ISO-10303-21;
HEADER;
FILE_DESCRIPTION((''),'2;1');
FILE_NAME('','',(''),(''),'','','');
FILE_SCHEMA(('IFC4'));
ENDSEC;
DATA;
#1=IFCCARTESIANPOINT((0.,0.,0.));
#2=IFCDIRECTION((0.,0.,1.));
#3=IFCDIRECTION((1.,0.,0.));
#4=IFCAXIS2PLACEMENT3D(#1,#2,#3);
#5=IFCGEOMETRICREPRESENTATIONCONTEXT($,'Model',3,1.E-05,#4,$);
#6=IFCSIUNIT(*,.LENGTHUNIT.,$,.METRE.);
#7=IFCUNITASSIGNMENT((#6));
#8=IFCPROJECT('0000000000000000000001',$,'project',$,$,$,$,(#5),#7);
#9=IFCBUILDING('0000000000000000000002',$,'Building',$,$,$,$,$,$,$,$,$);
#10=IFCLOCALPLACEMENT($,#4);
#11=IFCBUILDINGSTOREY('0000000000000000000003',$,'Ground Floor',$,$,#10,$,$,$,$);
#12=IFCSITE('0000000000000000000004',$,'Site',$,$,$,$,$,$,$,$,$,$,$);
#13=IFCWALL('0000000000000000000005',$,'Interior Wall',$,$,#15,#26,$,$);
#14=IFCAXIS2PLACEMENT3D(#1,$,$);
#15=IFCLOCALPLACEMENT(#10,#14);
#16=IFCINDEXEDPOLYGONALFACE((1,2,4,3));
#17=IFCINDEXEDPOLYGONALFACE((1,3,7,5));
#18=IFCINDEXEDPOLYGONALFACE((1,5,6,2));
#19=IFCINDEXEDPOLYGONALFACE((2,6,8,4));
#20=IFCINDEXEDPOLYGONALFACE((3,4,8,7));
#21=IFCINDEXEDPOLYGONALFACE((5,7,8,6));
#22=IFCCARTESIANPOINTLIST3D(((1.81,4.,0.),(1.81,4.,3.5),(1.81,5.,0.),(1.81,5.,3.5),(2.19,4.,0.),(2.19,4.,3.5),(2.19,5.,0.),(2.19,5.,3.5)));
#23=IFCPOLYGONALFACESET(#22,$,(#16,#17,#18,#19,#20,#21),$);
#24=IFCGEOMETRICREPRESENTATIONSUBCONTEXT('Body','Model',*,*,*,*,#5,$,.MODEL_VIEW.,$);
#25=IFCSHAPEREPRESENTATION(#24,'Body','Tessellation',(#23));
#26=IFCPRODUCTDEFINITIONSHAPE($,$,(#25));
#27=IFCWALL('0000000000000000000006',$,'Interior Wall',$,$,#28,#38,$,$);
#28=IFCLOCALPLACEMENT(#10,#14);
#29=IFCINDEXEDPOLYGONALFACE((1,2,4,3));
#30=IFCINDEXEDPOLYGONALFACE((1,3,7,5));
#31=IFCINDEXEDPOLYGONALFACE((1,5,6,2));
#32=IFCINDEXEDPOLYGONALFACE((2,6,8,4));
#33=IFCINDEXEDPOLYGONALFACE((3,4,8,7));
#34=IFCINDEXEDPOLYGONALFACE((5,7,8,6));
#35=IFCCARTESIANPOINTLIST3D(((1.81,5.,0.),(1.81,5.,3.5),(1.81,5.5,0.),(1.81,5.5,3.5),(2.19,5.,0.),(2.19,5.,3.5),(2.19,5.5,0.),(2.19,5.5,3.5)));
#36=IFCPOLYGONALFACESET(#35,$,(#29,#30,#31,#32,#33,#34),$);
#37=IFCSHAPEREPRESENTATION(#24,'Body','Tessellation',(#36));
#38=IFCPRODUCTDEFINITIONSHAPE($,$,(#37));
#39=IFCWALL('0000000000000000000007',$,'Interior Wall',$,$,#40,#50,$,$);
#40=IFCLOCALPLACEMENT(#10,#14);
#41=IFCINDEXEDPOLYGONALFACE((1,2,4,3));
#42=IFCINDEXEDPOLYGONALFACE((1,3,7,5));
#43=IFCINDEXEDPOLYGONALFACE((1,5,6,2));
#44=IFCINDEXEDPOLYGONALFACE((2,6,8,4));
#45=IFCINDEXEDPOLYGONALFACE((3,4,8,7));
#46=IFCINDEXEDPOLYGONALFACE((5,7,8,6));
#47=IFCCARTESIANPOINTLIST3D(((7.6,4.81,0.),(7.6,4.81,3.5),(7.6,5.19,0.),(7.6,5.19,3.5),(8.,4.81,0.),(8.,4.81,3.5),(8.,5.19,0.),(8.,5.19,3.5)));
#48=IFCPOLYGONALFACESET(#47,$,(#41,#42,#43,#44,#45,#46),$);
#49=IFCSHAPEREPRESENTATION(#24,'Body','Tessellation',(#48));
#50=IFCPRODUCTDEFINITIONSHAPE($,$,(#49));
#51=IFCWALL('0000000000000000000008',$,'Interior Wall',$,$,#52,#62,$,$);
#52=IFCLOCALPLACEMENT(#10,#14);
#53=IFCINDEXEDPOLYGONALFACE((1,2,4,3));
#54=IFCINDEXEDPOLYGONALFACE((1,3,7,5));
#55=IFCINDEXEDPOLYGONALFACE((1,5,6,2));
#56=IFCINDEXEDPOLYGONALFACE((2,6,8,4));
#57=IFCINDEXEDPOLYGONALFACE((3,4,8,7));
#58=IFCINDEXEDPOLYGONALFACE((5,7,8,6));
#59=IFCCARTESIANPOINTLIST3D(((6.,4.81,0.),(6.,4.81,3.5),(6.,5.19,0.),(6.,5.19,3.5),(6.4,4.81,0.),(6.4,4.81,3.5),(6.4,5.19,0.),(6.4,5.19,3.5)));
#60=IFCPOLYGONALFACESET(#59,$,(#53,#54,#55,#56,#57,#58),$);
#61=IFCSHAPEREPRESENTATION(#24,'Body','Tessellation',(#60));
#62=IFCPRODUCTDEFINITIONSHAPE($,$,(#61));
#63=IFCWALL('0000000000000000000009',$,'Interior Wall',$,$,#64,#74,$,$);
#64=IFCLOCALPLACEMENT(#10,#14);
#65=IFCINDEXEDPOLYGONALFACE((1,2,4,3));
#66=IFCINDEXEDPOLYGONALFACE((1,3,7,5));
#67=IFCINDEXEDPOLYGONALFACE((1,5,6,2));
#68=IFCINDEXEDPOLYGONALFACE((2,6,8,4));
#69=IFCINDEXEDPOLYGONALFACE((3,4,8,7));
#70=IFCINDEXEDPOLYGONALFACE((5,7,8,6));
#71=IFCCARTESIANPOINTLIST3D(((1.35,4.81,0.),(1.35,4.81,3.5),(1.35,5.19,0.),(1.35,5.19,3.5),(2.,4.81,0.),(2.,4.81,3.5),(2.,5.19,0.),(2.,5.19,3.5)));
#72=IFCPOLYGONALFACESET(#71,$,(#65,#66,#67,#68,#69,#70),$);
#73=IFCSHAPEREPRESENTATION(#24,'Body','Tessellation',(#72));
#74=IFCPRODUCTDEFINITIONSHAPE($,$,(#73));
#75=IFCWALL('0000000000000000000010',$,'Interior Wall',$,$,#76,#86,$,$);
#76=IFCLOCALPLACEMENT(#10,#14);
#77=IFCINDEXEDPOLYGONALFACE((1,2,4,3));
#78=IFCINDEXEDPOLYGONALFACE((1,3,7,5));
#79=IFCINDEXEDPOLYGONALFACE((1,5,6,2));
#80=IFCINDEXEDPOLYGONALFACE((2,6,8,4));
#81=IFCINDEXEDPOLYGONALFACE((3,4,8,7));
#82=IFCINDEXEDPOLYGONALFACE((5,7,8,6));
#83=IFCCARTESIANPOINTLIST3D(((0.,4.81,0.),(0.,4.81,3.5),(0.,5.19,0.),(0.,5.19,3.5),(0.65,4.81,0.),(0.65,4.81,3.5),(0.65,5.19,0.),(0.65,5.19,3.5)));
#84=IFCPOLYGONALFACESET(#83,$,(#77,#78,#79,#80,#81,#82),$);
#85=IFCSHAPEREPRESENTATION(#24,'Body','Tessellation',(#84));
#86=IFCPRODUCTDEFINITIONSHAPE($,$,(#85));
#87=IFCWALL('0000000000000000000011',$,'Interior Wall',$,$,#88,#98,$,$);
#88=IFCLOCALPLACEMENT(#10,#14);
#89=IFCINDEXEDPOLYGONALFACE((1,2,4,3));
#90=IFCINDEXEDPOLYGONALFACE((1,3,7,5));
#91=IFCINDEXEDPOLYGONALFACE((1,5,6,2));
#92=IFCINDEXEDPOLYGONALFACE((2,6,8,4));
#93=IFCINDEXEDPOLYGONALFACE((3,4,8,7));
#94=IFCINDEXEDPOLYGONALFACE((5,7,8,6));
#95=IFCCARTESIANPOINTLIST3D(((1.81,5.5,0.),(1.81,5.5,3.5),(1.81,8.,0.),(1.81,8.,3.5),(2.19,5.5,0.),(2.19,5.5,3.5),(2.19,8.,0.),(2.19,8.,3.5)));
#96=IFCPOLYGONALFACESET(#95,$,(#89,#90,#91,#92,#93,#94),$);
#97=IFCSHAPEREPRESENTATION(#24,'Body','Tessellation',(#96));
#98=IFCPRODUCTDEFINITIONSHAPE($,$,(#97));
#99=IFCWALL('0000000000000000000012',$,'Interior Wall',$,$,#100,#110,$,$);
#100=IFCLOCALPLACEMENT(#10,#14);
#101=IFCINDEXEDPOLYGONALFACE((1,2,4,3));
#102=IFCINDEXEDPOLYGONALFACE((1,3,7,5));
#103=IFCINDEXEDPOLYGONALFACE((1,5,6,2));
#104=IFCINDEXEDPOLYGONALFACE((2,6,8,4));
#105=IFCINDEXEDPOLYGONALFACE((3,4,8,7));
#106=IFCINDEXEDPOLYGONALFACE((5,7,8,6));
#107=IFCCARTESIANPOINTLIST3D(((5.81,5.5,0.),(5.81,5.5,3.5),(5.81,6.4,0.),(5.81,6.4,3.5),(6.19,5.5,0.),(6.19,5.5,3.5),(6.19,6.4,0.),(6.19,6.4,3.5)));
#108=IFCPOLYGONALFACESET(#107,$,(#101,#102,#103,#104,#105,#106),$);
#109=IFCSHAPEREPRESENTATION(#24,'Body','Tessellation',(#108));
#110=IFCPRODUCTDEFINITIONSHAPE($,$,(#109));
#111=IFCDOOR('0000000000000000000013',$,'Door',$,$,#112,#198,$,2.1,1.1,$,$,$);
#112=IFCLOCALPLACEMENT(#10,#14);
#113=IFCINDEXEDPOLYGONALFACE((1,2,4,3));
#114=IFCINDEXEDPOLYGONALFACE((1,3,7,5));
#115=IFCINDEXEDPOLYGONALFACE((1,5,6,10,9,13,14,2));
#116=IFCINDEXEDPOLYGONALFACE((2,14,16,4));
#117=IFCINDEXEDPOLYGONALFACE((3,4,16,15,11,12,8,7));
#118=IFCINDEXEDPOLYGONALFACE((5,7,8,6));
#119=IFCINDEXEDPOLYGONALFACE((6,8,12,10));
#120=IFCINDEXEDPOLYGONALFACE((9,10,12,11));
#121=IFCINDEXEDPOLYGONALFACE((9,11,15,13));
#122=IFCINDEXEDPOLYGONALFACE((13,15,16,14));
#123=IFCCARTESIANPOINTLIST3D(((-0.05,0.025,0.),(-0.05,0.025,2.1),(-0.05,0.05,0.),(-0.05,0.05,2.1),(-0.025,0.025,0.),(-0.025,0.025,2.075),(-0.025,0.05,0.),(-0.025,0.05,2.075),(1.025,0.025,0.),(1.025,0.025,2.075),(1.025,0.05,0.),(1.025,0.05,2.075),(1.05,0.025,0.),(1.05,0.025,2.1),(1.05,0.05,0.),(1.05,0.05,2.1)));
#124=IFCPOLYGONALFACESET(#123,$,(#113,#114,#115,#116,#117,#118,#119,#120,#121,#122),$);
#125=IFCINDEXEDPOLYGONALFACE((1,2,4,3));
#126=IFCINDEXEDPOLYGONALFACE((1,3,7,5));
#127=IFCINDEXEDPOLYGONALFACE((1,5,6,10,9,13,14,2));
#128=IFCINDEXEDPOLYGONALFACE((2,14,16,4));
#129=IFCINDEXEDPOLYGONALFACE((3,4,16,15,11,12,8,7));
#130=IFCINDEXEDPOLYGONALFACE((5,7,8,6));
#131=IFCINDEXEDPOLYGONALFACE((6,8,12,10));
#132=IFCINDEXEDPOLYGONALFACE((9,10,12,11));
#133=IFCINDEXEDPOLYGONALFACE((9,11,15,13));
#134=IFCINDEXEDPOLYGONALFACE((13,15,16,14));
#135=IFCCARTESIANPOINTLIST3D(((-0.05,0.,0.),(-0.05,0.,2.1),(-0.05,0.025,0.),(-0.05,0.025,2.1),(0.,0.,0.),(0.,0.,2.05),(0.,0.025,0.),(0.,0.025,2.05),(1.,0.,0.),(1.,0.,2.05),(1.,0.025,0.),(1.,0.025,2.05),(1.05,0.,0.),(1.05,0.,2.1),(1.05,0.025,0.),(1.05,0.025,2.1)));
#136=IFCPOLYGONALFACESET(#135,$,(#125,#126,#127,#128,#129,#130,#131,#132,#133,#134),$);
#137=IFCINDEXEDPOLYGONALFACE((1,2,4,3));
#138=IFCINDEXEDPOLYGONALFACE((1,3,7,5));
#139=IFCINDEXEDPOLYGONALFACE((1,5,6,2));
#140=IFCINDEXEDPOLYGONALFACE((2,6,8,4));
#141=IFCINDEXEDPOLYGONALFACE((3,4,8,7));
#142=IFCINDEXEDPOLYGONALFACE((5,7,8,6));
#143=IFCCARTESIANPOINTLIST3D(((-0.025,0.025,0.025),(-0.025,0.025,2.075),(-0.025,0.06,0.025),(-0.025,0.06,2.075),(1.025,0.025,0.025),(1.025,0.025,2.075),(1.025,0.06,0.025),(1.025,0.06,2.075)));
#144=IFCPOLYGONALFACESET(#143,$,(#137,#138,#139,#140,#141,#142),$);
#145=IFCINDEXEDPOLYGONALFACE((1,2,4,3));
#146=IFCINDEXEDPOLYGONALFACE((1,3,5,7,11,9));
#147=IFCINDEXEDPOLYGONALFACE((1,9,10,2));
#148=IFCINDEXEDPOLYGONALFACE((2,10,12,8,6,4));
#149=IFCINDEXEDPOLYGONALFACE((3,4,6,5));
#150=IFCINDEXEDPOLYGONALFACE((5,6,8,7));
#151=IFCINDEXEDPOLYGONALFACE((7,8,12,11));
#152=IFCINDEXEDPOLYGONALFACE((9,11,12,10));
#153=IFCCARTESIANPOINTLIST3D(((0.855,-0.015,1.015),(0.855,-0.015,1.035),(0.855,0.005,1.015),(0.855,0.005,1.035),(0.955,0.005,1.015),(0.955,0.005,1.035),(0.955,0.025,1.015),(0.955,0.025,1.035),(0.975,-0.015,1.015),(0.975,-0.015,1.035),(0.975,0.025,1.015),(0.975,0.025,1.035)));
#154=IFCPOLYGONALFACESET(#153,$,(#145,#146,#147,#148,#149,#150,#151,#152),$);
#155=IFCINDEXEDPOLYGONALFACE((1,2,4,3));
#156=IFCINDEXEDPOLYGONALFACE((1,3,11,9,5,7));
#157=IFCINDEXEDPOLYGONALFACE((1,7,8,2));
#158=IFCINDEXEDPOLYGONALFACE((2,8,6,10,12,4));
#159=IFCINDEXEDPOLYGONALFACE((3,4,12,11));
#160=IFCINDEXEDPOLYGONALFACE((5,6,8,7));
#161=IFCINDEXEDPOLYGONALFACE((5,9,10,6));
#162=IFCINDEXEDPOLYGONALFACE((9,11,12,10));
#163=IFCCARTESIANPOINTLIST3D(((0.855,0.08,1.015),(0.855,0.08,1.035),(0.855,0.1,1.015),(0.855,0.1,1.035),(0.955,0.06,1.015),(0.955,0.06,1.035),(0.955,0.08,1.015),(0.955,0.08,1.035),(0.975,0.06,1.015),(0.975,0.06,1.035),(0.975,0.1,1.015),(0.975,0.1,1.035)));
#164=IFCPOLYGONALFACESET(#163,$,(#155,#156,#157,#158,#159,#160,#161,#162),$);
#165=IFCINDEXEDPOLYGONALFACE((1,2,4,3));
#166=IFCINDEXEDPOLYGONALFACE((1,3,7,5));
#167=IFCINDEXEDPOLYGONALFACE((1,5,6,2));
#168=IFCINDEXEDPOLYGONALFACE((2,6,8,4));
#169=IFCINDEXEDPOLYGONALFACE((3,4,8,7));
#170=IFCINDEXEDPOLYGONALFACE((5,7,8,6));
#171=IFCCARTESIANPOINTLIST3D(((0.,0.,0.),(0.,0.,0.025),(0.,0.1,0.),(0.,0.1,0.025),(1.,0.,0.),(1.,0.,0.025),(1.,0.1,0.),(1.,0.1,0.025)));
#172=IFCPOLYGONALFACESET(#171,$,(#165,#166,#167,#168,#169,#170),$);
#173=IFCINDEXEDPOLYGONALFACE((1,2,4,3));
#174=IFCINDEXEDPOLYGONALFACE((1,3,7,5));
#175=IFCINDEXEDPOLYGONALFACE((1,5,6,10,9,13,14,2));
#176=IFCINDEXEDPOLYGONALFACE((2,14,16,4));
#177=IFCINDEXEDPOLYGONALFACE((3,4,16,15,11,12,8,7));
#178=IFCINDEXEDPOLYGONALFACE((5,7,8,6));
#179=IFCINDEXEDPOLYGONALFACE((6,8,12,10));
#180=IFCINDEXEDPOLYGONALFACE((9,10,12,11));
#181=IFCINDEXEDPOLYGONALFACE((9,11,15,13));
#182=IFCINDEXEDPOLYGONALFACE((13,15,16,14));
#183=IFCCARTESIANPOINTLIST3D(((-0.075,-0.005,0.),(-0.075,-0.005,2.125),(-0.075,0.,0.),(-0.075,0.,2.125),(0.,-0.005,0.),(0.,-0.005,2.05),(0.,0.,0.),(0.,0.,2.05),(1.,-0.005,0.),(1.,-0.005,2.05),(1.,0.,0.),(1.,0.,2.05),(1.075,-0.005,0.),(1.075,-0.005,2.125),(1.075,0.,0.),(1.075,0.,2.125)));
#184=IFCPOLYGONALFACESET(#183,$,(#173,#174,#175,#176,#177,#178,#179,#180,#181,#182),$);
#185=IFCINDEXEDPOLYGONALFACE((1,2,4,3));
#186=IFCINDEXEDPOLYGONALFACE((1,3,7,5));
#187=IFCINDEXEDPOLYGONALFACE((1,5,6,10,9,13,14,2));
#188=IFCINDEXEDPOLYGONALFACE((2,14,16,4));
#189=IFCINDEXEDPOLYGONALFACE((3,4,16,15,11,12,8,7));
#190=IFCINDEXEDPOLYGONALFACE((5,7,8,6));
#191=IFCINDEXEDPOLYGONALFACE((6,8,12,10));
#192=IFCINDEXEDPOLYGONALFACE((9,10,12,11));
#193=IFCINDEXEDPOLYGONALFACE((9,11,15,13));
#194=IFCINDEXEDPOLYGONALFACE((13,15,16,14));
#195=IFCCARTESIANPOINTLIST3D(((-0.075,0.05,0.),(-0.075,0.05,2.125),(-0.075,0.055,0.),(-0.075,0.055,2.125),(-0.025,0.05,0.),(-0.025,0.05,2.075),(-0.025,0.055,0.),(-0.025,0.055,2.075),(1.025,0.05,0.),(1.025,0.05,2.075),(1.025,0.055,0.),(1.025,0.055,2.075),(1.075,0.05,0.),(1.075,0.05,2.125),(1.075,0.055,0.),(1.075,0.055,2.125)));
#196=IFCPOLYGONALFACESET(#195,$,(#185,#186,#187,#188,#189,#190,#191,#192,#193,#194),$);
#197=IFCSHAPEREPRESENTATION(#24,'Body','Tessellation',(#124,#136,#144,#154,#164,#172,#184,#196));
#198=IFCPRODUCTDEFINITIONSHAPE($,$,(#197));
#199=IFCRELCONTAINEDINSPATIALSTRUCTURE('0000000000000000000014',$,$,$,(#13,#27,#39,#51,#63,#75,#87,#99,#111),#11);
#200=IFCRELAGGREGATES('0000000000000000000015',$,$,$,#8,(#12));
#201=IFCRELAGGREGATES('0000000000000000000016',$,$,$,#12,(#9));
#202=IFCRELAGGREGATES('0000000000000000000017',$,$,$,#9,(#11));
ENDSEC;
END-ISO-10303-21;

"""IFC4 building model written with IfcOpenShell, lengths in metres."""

from ifc_helpers import new_model, si_unit, frame, origin_with_axes, place, context, subcontext, project, spatial, line, indexed_curve, outline, extrude, element, save


model = new_model("IFC4")

# Units and contexts
model_context = context("Model", 3, precision=1e-05, world=origin_with_axes())
body_context = subcontext(model_context, "Body", "Model", "MODEL_VIEW")
ifc_project = project(units=[si_unit("LENGTHUNIT", "METRE")], contexts=[model_context])

# Site, building, storey
site = spatial("IfcSite", under=ifc_project, Name="Site")
building = spatial("IfcBuilding", under=site, Name="Building")
storey_placement = place(None, origin_with_axes())
storey = spatial("IfcBuildingStorey", under=building, at=storey_placement, Name="Ground Floor")

# Walls
wall_1_placement = place(storey_placement, frame((2.0, 5.0, 0.0), z_axis=(0.0, 0.0, 1.0), x_axis=(0.0, -1.0, 0.0)))
element("IfcWall", 1, at=wall_1_placement, inside=storey, Name="Interior Wall", context=body_context, shape_type="SweptSolid", body=[
    extrude(outline(indexed_curve([(0.0, 0.0), (0.0, 0.38), (1.0, 0.38), (1.0, 0.0), (0.0, 0.0)], self_intersect=False)), frame((0.0, -0.19, 0.0), z_axis=(0.0, 0.0, 1.0), x_axis=(1.0, 0.0, 0.0)), (0.0, 0.0, 1.0), 3.5),
])
wall_2_placement = place(storey_placement, frame((2.0, 5.5, 0.0), z_axis=(0.0, 0.0, 1.0), x_axis=(0.0, -1.0, 0.0)))
element("IfcWall", 2, at=wall_2_placement, inside=storey, Name="Interior Wall", context=body_context, shape_type="SweptSolid", body=[
    extrude(outline(indexed_curve([(0.0, 0.0), (0.0, 0.38), (0.5, 0.38), (0.5, 0.0), (0.0, 0.0)], self_intersect=False)), frame((0.0, -0.19, 0.0), z_axis=(0.0, 0.0, 1.0), x_axis=(1.0, 0.0, 0.0)), (0.0, 0.0, 1.0), 3.5),
])
for number, where, z_axis, x_axis, name in (
    (3, (8.0, 5.0, 0.0), (0.0, 0.0, 1.0), (-1.0, 0.0, 0.0), "Interior Wall"),
    (4, (6.4, 5.0, 0.0), (0.0, 0.0, 1.0), (-1.0, 0.0, 0.0), "Interior Wall"),
):
    element("IfcWall", number, at=place(storey_placement, frame(where, z_axis=z_axis, x_axis=x_axis)), inside=storey, Name=name, context=body_context, shape_type="SweptSolid", body=[
        extrude(outline(indexed_curve([(0.0, 0.0), (0.0, 0.38), (0.4, 0.38), (0.4, 0.0), (0.0, 0.0)], self_intersect=False)), frame((0.0, -0.19, 0.0), z_axis=(0.0, 0.0, 1.0), x_axis=(1.0, 0.0, 0.0)), (0.0, 0.0, 1.0), 3.5),
    ])
for number, where, z_axis, x_axis, name in (
    (5, (2.0, 5.0, 0.0), (0.0, 0.0, 1.0), (-1.0, 0.0, 0.0), "Interior Wall"),
    (6, (0.65, 5.0, 0.0), (0.0, 0.0, 1.0), (-1.0, 0.0, 0.0), "Interior Wall"),
):
    element("IfcWall", number, at=place(storey_placement, frame(where, z_axis=z_axis, x_axis=x_axis)), inside=storey, Name=name, context=body_context, shape_type="SweptSolid", body=[
        extrude(outline(indexed_curve([(0.0, 0.0), (0.0, 0.38), (0.65, 0.38), (0.65, 0.0), (0.0, 0.0)], self_intersect=False)), frame((0.0, -0.19, 0.0), z_axis=(0.0, 0.0, 1.0), x_axis=(1.0, 0.0, 0.0)), (0.0, 0.0, 1.0), 3.5),
    ])
wall_3_placement = place(storey_placement, frame((2.0, 5.5, 0.0), z_axis=(0.0, 0.0, 1.0), x_axis=(0.0, 1.0, 0.0)))
element("IfcWall", 7, at=wall_3_placement, inside=storey, Name="Interior Wall", context=body_context, shape_type="SweptSolid", body=[
    extrude(outline(indexed_curve([(0.0, 0.0), (0.0, 0.38), (2.5, 0.38), (2.5, 0.0), (0.0, 0.0)], self_intersect=False)), frame((0.0, -0.19, 0.0), z_axis=(0.0, 0.0, 1.0), x_axis=(1.0, 0.0, 0.0)), (0.0, 0.0, 1.0), 3.5),
])
wall_4_placement = place(storey_placement, frame((6.0, 5.5, 0.0), z_axis=(0.0, 0.0, 1.0), x_axis=(0.0, 1.0, 0.0)))
element("IfcWall", 8, at=wall_4_placement, inside=storey, Name="Interior Wall", context=body_context, shape_type="SweptSolid", body=[
    extrude(outline(indexed_curve([(0.0, 0.0), (0.0, 0.38), (0.9, 0.38), (0.9, 0.0), (0.0, 0.0)], self_intersect=False)), frame((0.0, -0.19, 0.0), z_axis=(0.0, 0.0, 1.0), x_axis=(1.0, 0.0, 0.0)), (0.0, 0.0, 1.0), 3.5),
])

# Door
door_1_placement = place(storey_placement, frame((-0.05, 0.0, 0.0), z_axis=(0.0, 0.0, 1.0), x_axis=(1.0, 0.0, 0.0)))
element("IfcDoor", 9, at=door_1_placement, inside=storey, Name="Door", OverallHeight=2.1, OverallWidth=1.1, context=body_context, shape_type="SweptSolid", body=[
    extrude(outline(indexed_curve([(0.0, 0.0), (0.0, 2.1), (1.1, 2.1), (1.1, 0.0), (1.075, 0.0), (1.075, 2.075), (0.025, 2.075), (0.025, 0.0)], segments=[line(1, 2, 3, 4, 5, 6, 7, 8, 1)])), frame((0.0, 0.025, 0.0), z_axis=(0.0, -1.0, 0.0), x_axis=(1.0, 0.0, 0.0)), (0.0, 0.0, -1.0), 0.025),
    extrude(outline(indexed_curve([(0.0, 0.0), (0.0, 2.1), (1.1, 2.1), (1.1, 0.0), (1.05, 0.0), (1.05, 2.05), (0.05, 2.05), (0.05, 0.0)], segments=[line(1, 2, 3, 4, 5, 6, 7, 8, 1)])), frame((0.0, 0.0, 0.0), z_axis=(0.0, -1.0, 0.0), x_axis=(1.0, 0.0, 0.0)), (0.0, 0.0, -1.0), 0.025),
    extrude(outline(indexed_curve([(0.0, 0.0), (1.05, 0.0), (1.05, 0.035), (0.0, 0.035)], segments=[line(1, 2, 3, 4, 1)])), frame((0.025, 0.025, 0.025), z_axis=(0.0, 0.0, 1.0), x_axis=(1.0, 0.0, 0.0)), (0.0, 0.0, 1.0), 2.05),
    extrude(outline(indexed_curve([(0.0, 0.0), (0.0, -0.04), (-0.12, -0.04), (-0.12, -0.02), (-0.02, -0.02), (-0.02, 0.0)], segments=[line(1, 2, 3, 4, 5, 6, 1)])), frame((1.025, 0.025, 1.015), z_axis=(0.0, 0.0, 1.0), x_axis=(1.0, 0.0, 0.0)), (0.0, 0.0, 1.0), 0.02),
    extrude(outline(indexed_curve([(0.0, 0.0), (0.0, 0.04), (-0.12, 0.04), (-0.12, 0.02), (-0.02, 0.02), (-0.02, 0.0)], segments=[line(1, 2, 3, 4, 5, 6, 1)])), frame((1.025, 0.06, 1.015), z_axis=(0.0, 0.0, 1.0), x_axis=(1.0, 0.0, 0.0)), (0.0, 0.0, 1.0), 0.02),
    extrude(outline(indexed_curve([(0.0, 0.0), (1.0, 0.0), (1.0, 0.1), (0.0, 0.1)], segments=[line(1, 2, 3, 4, 1)])), frame((0.05, 0.0, 0.0), z_axis=(0.0, 0.0, 1.0), x_axis=(1.0, 0.0, 0.0)), (0.0, 0.0, 1.0), 0.025),
    extrude(outline(indexed_curve([(0.0, 0.0), (0.0, 2.125), (1.15, 2.125), (1.15, 0.0), (1.075, 0.0), (1.075, 2.05), (0.075, 2.05), (0.075, 0.0)], segments=[line(1, 2, 3, 4, 5, 6, 7, 8, 1)])), frame((-0.025, -0.005, 0.0), z_axis=(0.0, -1.0, 0.0), x_axis=(1.0, 0.0, 0.0)), (0.0, 0.0, -1.0), 0.005),
    extrude(outline(indexed_curve([(0.0, 0.0), (0.0, 2.125), (1.15, 2.125), (1.15, 0.0), (1.1, 0.0), (1.1, 2.075), (0.05, 2.075), (0.05, 0.0)], segments=[line(1, 2, 3, 4, 5, 6, 7, 8, 1)])), frame((-0.025, 0.05, 0.0), z_axis=(0.0, -1.0, 0.0), x_axis=(1.0, 0.0, 0.0)), (0.0, 0.0, -1.0), 0.005),
])

save(model, "model.ifc")
